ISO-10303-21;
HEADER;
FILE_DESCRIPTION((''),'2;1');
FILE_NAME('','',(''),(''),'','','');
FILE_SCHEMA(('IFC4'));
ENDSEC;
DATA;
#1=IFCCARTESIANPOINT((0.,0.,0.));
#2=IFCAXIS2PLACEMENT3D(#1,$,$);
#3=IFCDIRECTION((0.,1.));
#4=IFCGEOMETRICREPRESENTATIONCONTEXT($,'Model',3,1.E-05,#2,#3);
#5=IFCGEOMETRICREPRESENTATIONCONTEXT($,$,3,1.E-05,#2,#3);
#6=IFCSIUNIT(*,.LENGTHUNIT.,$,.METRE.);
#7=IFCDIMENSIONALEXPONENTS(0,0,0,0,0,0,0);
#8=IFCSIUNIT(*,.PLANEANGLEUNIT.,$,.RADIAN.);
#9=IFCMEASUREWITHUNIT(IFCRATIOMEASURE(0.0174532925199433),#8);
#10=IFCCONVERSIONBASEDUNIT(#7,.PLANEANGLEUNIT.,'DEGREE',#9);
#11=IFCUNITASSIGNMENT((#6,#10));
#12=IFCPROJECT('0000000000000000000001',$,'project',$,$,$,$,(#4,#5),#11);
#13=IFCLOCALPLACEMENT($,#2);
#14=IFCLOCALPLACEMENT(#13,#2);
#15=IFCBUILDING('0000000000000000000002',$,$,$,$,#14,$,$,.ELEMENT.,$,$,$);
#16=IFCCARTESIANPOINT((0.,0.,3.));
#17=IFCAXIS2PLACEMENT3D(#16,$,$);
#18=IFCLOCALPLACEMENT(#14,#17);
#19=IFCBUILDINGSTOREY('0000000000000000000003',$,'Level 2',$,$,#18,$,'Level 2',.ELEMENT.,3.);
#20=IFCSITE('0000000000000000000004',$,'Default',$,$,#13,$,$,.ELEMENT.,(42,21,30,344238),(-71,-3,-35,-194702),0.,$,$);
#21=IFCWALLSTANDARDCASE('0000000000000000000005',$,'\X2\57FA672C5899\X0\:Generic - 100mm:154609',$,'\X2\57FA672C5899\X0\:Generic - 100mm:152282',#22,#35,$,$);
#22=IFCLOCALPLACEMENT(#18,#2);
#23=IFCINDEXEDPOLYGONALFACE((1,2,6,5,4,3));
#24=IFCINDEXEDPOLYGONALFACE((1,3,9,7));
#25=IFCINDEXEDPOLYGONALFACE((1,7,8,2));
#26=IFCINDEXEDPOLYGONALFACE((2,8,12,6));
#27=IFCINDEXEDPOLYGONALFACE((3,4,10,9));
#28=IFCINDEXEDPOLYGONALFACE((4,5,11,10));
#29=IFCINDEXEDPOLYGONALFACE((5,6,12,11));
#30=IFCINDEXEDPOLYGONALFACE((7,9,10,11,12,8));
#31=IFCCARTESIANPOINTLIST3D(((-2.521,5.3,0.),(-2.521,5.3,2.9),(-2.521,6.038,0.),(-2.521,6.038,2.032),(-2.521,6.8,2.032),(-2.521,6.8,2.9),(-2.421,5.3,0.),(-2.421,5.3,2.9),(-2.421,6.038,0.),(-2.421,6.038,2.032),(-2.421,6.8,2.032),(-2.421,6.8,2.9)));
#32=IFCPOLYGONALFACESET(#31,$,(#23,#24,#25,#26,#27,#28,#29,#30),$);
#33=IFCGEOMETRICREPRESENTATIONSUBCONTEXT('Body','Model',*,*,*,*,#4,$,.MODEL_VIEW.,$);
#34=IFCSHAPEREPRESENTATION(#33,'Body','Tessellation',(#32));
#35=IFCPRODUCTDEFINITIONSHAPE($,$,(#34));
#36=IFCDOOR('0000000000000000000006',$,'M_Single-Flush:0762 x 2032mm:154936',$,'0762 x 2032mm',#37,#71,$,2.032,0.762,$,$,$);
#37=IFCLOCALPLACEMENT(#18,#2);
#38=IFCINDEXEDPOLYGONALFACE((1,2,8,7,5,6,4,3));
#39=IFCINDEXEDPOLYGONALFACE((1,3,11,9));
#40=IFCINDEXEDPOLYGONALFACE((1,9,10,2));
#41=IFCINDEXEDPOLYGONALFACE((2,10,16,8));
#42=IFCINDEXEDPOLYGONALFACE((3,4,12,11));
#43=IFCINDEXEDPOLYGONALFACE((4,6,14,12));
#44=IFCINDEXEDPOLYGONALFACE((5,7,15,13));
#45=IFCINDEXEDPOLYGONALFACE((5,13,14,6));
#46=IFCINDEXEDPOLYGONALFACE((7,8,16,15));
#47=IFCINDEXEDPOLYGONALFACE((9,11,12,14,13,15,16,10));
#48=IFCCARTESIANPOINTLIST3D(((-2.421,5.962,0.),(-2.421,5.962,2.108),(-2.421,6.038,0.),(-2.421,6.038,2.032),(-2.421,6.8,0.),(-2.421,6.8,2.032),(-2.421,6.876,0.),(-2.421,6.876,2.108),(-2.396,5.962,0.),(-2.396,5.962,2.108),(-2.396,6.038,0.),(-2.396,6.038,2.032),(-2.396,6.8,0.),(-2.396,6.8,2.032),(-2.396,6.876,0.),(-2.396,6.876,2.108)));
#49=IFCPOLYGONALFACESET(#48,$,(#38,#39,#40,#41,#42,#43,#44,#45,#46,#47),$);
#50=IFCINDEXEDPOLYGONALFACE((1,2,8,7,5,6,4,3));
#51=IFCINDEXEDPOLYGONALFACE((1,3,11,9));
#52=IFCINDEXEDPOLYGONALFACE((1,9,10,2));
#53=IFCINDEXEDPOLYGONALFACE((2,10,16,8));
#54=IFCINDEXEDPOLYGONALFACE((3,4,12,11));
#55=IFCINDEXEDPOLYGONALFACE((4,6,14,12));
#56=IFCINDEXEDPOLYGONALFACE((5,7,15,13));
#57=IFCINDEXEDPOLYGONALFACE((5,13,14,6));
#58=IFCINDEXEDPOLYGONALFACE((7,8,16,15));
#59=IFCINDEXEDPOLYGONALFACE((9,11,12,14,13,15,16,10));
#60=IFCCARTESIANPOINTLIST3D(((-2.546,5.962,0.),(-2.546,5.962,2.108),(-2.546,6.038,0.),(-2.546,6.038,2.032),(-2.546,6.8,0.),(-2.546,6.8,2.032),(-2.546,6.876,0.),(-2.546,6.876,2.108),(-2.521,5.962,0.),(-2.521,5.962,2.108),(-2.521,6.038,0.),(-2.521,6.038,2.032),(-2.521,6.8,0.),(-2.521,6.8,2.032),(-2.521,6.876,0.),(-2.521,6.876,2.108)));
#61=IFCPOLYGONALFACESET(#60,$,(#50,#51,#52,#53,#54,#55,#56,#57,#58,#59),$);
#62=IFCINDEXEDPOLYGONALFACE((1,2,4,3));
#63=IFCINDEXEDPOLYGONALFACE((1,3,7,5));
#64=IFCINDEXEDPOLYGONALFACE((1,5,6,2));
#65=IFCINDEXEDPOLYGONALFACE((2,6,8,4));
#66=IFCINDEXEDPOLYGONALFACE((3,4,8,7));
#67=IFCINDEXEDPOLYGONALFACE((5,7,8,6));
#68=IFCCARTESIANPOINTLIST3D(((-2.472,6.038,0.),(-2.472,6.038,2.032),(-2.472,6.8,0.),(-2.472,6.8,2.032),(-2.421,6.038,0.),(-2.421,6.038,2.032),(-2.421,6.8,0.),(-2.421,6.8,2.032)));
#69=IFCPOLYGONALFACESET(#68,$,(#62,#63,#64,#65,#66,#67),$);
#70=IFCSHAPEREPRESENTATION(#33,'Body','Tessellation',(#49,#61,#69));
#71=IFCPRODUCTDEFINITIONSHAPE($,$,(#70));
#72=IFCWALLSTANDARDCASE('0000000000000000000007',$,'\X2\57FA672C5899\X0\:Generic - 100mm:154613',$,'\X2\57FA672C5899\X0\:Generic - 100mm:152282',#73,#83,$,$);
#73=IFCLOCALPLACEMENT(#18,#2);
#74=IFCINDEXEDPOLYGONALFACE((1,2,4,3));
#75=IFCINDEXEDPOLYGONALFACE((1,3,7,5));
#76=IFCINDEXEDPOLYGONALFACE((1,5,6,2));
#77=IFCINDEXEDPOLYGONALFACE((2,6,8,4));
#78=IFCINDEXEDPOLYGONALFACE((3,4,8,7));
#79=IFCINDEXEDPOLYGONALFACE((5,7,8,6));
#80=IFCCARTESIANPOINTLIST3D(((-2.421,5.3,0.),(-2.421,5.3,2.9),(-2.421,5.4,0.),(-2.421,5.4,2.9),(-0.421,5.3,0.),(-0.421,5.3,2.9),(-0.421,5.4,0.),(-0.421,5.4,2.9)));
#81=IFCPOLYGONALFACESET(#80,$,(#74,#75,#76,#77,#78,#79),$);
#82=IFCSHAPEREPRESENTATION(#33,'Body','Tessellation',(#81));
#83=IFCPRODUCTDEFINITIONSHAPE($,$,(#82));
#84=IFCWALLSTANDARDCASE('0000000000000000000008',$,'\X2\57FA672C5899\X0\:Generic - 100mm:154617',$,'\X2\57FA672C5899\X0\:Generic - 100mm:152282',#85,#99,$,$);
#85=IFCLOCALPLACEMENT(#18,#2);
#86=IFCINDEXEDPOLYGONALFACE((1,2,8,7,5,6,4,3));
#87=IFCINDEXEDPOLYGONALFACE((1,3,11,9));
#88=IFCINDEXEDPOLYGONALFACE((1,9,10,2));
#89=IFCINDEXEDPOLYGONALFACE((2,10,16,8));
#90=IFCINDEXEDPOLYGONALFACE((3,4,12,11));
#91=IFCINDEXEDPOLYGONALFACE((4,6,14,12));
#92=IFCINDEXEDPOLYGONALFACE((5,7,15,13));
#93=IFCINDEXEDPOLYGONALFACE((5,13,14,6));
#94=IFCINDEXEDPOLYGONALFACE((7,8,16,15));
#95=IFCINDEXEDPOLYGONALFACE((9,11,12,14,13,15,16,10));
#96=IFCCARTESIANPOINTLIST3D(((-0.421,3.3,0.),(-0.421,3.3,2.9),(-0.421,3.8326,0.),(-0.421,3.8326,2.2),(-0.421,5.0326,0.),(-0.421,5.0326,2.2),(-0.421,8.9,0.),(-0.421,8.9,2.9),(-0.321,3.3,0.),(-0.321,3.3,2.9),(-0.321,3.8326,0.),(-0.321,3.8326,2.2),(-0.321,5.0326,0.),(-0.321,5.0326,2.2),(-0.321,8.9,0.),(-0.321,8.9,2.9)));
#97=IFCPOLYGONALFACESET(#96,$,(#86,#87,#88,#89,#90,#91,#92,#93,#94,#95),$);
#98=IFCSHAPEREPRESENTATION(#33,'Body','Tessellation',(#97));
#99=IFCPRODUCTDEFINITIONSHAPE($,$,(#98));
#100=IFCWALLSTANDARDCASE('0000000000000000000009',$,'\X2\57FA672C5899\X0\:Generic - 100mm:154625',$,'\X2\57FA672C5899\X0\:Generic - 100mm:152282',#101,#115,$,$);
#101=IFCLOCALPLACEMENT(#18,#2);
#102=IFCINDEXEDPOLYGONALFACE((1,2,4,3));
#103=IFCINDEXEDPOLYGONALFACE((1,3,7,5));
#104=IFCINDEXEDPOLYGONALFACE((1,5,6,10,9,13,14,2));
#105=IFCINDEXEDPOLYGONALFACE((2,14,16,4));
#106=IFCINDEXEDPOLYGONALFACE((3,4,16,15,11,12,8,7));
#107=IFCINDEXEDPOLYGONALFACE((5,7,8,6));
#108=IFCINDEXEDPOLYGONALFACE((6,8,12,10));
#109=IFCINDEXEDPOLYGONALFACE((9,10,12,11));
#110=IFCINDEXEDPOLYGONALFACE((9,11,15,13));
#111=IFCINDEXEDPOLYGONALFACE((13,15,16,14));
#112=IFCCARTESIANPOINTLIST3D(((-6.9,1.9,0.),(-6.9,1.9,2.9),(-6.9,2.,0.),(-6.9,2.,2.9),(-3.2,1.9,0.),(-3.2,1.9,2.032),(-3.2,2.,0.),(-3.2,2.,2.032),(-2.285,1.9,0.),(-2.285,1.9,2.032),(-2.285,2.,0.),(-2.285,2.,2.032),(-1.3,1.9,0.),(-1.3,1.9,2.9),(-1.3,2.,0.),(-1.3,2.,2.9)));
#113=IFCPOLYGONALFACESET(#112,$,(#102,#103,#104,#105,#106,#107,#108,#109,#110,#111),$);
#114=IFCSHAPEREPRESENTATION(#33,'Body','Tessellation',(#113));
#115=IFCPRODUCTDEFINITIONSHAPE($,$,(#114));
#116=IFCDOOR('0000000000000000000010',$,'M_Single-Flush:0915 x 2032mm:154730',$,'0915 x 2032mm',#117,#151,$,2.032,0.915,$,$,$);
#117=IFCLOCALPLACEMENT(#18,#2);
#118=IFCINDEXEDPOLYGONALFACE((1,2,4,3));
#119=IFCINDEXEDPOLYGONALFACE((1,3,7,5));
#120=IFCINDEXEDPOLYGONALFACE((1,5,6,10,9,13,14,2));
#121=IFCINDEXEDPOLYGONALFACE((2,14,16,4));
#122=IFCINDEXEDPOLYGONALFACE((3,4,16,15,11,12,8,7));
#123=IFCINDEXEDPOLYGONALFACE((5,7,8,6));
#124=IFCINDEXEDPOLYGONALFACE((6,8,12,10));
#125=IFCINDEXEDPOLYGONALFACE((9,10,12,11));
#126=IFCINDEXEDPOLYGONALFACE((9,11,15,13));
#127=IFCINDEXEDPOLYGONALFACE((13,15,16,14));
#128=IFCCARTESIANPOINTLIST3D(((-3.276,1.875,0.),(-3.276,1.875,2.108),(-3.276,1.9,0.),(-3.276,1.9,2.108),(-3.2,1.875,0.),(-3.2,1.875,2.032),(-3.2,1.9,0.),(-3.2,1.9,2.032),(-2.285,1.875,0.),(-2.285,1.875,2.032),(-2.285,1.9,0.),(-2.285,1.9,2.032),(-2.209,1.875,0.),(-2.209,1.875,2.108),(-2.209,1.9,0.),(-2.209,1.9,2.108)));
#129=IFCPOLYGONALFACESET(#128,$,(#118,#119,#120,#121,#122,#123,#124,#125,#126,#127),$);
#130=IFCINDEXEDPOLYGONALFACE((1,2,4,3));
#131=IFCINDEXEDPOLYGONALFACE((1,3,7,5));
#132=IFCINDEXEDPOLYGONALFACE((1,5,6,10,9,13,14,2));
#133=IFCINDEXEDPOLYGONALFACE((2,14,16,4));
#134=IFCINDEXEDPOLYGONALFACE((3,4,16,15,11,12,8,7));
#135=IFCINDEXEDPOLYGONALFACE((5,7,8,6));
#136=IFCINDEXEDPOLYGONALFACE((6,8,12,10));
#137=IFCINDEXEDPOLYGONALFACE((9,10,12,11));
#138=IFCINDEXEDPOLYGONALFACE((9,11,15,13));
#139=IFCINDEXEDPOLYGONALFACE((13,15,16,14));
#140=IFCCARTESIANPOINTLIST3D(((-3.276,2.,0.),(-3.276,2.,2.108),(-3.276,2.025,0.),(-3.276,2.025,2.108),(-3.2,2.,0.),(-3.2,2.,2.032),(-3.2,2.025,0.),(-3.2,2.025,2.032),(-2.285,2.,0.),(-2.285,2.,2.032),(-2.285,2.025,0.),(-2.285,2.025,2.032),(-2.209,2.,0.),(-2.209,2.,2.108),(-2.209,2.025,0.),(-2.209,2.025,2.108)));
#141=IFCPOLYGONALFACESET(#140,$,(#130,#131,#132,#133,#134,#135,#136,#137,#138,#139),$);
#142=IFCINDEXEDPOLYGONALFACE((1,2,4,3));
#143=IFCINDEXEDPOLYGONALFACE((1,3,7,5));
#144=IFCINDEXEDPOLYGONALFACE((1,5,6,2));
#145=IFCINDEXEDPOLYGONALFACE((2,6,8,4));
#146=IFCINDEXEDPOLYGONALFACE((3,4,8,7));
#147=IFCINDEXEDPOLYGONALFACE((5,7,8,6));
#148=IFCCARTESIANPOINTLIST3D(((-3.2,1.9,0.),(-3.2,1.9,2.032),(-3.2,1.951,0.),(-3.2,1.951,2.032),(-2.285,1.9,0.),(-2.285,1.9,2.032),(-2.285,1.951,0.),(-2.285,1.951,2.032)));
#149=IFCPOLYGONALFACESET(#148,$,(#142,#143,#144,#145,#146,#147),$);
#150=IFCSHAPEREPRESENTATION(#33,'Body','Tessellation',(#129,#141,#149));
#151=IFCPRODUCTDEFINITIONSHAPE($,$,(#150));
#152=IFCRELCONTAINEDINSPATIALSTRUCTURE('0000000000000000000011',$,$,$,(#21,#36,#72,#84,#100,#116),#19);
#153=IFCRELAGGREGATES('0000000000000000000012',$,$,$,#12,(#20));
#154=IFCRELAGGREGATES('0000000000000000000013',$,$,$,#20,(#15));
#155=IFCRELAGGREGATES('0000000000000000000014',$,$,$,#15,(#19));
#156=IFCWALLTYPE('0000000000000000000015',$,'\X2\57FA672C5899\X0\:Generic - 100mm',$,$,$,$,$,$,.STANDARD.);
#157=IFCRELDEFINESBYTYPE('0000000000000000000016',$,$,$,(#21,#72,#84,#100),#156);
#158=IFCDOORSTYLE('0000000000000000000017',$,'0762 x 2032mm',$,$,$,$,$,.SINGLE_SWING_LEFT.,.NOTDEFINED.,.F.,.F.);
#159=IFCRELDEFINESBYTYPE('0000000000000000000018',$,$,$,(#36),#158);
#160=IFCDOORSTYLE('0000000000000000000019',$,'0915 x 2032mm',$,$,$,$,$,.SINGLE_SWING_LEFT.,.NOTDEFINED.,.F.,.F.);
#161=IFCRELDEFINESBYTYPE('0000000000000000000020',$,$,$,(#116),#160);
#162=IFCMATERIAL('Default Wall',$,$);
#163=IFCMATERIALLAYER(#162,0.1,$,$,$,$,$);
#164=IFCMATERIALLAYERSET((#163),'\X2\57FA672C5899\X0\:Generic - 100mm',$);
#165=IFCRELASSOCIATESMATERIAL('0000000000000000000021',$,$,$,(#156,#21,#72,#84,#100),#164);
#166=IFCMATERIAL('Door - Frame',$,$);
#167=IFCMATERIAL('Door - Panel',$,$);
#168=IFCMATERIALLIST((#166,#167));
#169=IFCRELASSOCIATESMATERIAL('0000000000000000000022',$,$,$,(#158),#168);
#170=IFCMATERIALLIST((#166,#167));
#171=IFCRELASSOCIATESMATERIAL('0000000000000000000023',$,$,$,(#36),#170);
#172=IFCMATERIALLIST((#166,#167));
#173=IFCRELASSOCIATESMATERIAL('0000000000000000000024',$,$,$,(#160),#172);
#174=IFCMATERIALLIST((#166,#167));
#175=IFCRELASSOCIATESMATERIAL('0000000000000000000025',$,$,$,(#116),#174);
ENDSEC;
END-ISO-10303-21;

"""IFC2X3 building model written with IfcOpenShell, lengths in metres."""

from ifc_helpers import new_model, entity, si_unit, converted_unit, direction, frame, frame_2d, origin, origin_2d_with_axis, place, context, subcontext, project, spatial, polyline, rectangle, outline, extrude, clip, bounded_halfspace, source, transform, mapped, material, material_list, layer, layer_set, layer_usage, type_object, type_shapes, element, fill, save


model = new_model("IFC2X3")

# Units and contexts
model_context = context("Model", 3, precision=1e-05, world=origin(), true_north=direction((0.0, 1.0)))
context_of_model = context(None, 3, precision=1e-05, world=origin(), true_north=direction((0.0, 1.0)))
body_context = subcontext(model_context, "Body", "Model", "MODEL_VIEW")
ifc_project = project(units=[si_unit("LENGTHUNIT", "METRE"), converted_unit("PLANEANGLEUNIT", "DEGREE", entity("IfcRatioMeasure", 0.0174532925199433), si_unit("PLANEANGLEUNIT", "RADIAN"), dimensions=[0, 0, 0, 0, 0, 0, 0])], contexts=[model_context, context_of_model])

# Site, building, storey
site_placement = place(None, origin())
site = spatial("IfcSite", under=ifc_project, at=site_placement, Name="Default", CompositionType="ELEMENT", RefLatitude=(42, 21, 30, 344238), RefLongitude=(-71, -3, -35, -194702), RefElevation=0.0)
building_placement = place(site_placement, origin())
building = spatial("IfcBuilding", under=site, at=building_placement, CompositionType="ELEMENT")
storey_placement = place(building_placement, frame((0.0, 0.0, 3.0)))
storey = spatial("IfcBuildingStorey", under=building, at=storey_placement, Name="Level 2", LongName="Level 2", CompositionType="ELEMENT", Elevation=3.0)

# Shared definitions
ifc_material_1 = material(Name="Default Wall")
ifc_material_2 = material(Name="Door - Panel")
ifc_material_3 = material(Name="Door - Frame")

# Wall, opening, door
ifc_layer_1 = layer(ifc_material_1, 0.1)
ifc_layer_set_1 = layer_set([ifc_layer_1], Name="基本墙:Generic - 100mm")
ifc_layer_usage_1 = layer_usage(ifc_layer_set_1, "AXIS2", "NEGATIVE", 0.05)
wall_type_1 = type_object("IfcWallType", Name="基本墙:Generic - 100mm", PredefinedType="STANDARD", material=ifc_layer_set_1)
wall_1_placement = place(storey_placement, frame((-2.471, 5.3, 0.0), z_axis=(0.0, 0.0, 1.0), x_axis=(0.0, 1.0, 0.0)))
wall_1 = element("IfcWallStandardCase", 1, at=wall_1_placement, inside=storey, type_object=wall_type_1, material=ifc_layer_usage_1, Name="基本墙:Generic - 100mm:154609", ObjectType="基本墙:Generic - 100mm:152282", context=body_context, shape_type="Clipping", body=[
    clip(extrude(rectangle(XDim=1.5, YDim=0.1, at=frame_2d((0.75, 0.0), x_axis=(-1.0, 0.0))), origin(), (0.0, 0.0, 1.0), 3.2), bounded_halfspace(frame((0.0, -0.05, 2.9), z_axis=(0.0, 0.0, -1.0), x_axis=(-1.0, 0.0, 0.0)), True, frame((0.0, -0.05, 2.9), z_axis=(0.0, 0.0, -1.0), x_axis=(-1.0, 0.0, 0.0)), polyline([(0.0, 0.0), (0.0, 0.1), (-1.5, 0.1), (-1.5, 0.0), (-0.1, 0.0), (0.0, 0.0)]))),
])
opening_1_placement = place(wall_1_placement, frame((1.5, 0.05, 0.0)))
opening_1 = element("IfcOpeningElement", 2, at=opening_1_placement, cuts=wall_1, ObjectType="Opening", context=body_context, shape_type="SweptSolid", body=[
    extrude(rectangle(XDim=0.762, YDim=2.032, at=frame_2d((1.016, 0.381), x_axis=(0.0, -1.0))), frame((0.0, 0.0, 0.0), z_axis=(0.0, -1.0, 0.0), x_axis=(0.0, 0.0, 1.0)), (0.0, 0.0, 1.0), 0.1),
])
ifc_material_list_1 = material_list([ifc_material_3, ifc_material_2])
ifc_material_list_2 = material_list([ifc_material_3, ifc_material_2])
door_style_1 = type_object("IfcDoorStyle", Name="0762 x 2032mm", ConstructionType="NOTDEFINED", OperationType="SINGLE_SWING_LEFT", ParameterTakesPrecedence=False, Sizeable=False, material=ifc_material_list_2)
shared_shape_1 = source(origin(), body_context, "Body", "SweptSolid", [
    extrude(outline(polyline([(-0.457, -1.073), (0.457, -1.073), (0.457, 1.035), (0.381, 1.035), (0.381, -0.997), (-0.381, -0.997), (-0.381, 1.035), (-0.457, 1.035), (-0.457, -1.073)])), frame((0.381, 0.125, 1.035), z_axis=(0.0, -1.0, 0.0), x_axis=(-1.0, 0.0, 0.0)), (0.0, 0.0, 1.0), 0.025),
    extrude(outline(polyline([(-1.073, -0.457), (1.035, -0.457), (1.035, -0.381), (-0.997, -0.381), (-0.997, 0.381), (1.035, 0.381), (1.035, 0.457), (-1.073, 0.457), (-1.073, -0.457)])), frame((0.381, 0.0, 1.035), z_axis=(0.0, -1.0, 0.0), x_axis=(0.0, 0.0, -1.0)), (0.0, 0.0, 1.0), 0.025),
    extrude(rectangle(XDim=0.762, YDim=0.051, at=origin_2d_with_axis()), frame((0.381, 0.0745, 0.0)), (0.0, 0.0, 1.0), 2.032),
])
type_shapes(door_style_1, [shared_shape_1])
door_1_placement = place(opening_1_placement, frame((0.0, 0.0, 0.0), z_axis=(0.0, 0.0, 1.0), x_axis=(-1.0, 0.0, 0.0)))
door_1 = element("IfcDoor", 3, at=door_1_placement, inside=storey, type_object=door_style_1, material=ifc_material_list_1, Name="M_Single-Flush:0762 x 2032mm:154936", ObjectType="0762 x 2032mm", OverallHeight=2.032, OverallWidth=0.762, context=body_context, shape_type="MappedRepresentation", body=[
    mapped(shared_shape_1, transform((0.0, 0.0, 0.0), scale=1.0)),
])
fill(opening_1, door_1)

# Wall
ifc_layer_usage_2 = layer_usage(ifc_layer_set_1, "AXIS2", "NEGATIVE", 0.05)
wall_2_placement = place(storey_placement, frame((-0.421, 5.35, 0.0), z_axis=(0.0, 0.0, 1.0), x_axis=(-1.0, 0.0, 0.0)))
element("IfcWallStandardCase", 4, at=wall_2_placement, inside=storey, type_object=wall_type_1, material=ifc_layer_usage_2, Name="基本墙:Generic - 100mm:154613", ObjectType="基本墙:Generic - 100mm:152282", context=body_context, shape_type="Clipping", body=[
    clip(extrude(rectangle(XDim=2.0, YDim=0.1, at=frame_2d((1.0, 0.0), x_axis=(-1.0, 0.0))), origin(), (0.0, 0.0, 1.0), 3.2), bounded_halfspace(frame((0.0, -0.05, 2.9), z_axis=(0.0, 0.0, -1.0), x_axis=(0.0, 1.0, 0.0)), True, frame((0.0, -0.05, 2.9), z_axis=(0.0, 0.0, -1.0), x_axis=(0.0, 1.0, 0.0)), polyline([(0.0, 0.0), (0.1, 0.0), (0.1, 2.0), (0.0, 2.0), (0.0, 0.0)]))),
])

# Wall, opening
ifc_layer_usage_3 = layer_usage(ifc_layer_set_1, "AXIS2", "NEGATIVE", 0.05)
wall_3_placement = place(storey_placement, frame((-0.371, 8.9, 0.0), z_axis=(0.0, 0.0, 1.0), x_axis=(0.0, -1.0, 0.0)))
wall_3 = element("IfcWallStandardCase", 5, at=wall_3_placement, inside=storey, type_object=wall_type_1, material=ifc_layer_usage_3, Name="基本墙:Generic - 100mm:154617", ObjectType="基本墙:Generic - 100mm:152282", context=body_context, shape_type="Clipping", body=[
    clip(extrude(rectangle(XDim=5.6, YDim=0.1, at=frame_2d((2.8, 0.0), x_axis=(-1.0, 0.0))), origin(), (0.0, 0.0, 1.0), 3.2), bounded_halfspace(frame((0.0, -0.05, 2.9), z_axis=(0.0, 0.0, -1.0), x_axis=(1.0, 0.0, 0.0)), True, frame((0.0, -0.05, 2.9), z_axis=(0.0, 0.0, -1.0), x_axis=(1.0, 0.0, 0.0)), polyline([(0.0, 0.0), (0.0, -0.1), (5.6, -0.1), (5.6, 0.0), (3.6, 0.0), (3.5, 0.0), (2.1, 0.0), (2.0, 0.0), (0.0, 0.0)]))),
])
opening_2_placement = place(wall_3_placement, frame((5.0674, -0.05, 0.0)))
element("IfcOpeningElement", 6, at=opening_2_placement, cuts=wall_3, ObjectType="Opening", context=body_context, shape_type="SweptSolid", body=[
    extrude(rectangle(XDim=2.2, YDim=1.2, at=frame_2d((0.0, 0.0), x_axis=(1.0, 0.0))), frame((-0.6, 0.0, 1.1), z_axis=(0.0, 1.0, 0.0), x_axis=(0.0, 0.0, -1.0)), (0.0, 0.0, 1.0), 0.1),
])

# Wall, opening, door
ifc_layer_usage_4 = layer_usage(ifc_layer_set_1, "AXIS2", "NEGATIVE", 0.05)
wall_4_placement = place(storey_placement, frame((-1.3, 1.95, 0.0), z_axis=(0.0, 0.0, 1.0), x_axis=(-1.0, 0.0, 0.0)))
wall_4 = element("IfcWallStandardCase", 7, at=wall_4_placement, inside=storey, type_object=wall_type_1, material=ifc_layer_usage_4, Name="基本墙:Generic - 100mm:154625", ObjectType="基本墙:Generic - 100mm:152282", context=body_context, shape_type="Clipping", body=[
    clip(extrude(rectangle(XDim=5.6, YDim=0.1, at=frame_2d((2.8, 0.0), x_axis=(-1.0, 0.0))), origin(), (0.0, 0.0, 1.0), 3.2), bounded_halfspace(frame((0.0, -0.05, 2.9), z_axis=(0.0, 0.0, -1.0), x_axis=(0.0, 1.0, 0.0)), True, frame((0.0, -0.05, 2.9), z_axis=(0.0, 0.0, -1.0), x_axis=(0.0, 1.0, 0.0)), polyline([(0.0, 0.0), (0.1, 0.0), (0.1, 5.6), (0.0, 5.6), (0.0, 0.0)]))),
])
opening_3_placement = place(wall_4_placement, frame((0.985, -0.05, 0.0)))
opening_3 = element("IfcOpeningElement", 8, at=opening_3_placement, cuts=wall_4, ObjectType="Opening", context=body_context, shape_type="SweptSolid", body=[
    extrude(rectangle(XDim=0.915, YDim=2.032, at=frame_2d((1.016, 0.4575), x_axis=(0.0, -1.0))), frame((0.0, 0.0, 0.0), z_axis=(0.0, 1.0, 0.0), x_axis=(0.0, 0.0, 1.0)), (0.0, 0.0, 1.0), 0.1),
])
ifc_material_list_3 = material_list([ifc_material_3, ifc_material_2])
ifc_material_list_4 = material_list([ifc_material_3, ifc_material_2])
door_style_2 = type_object("IfcDoorStyle", Name="0915 x 2032mm", ConstructionType="NOTDEFINED", OperationType="SINGLE_SWING_LEFT", ParameterTakesPrecedence=False, Sizeable=False, material=ifc_material_list_4)
shared_shape_2 = source(origin(), body_context, "Body", "SweptSolid", [
    extrude(outline(polyline([(-0.5335, -1.073), (0.5335, -1.073), (0.5335, 1.035), (0.4575, 1.035), (0.4575, -0.997), (-0.4575, -0.997), (-0.4575, 1.035), (-0.5335, 1.035), (-0.5335, -1.073)])), frame((0.4575, 0.125, 1.035), z_axis=(0.0, -1.0, 0.0), x_axis=(-1.0, 0.0, 0.0)), (0.0, 0.0, 1.0), 0.025),
    extrude(outline(polyline([(-1.073, -0.5335), (1.035, -0.5335), (1.035, -0.4575), (-0.997, -0.4575), (-0.997, 0.4575), (1.035, 0.4575), (1.035, 0.5335), (-1.073, 0.5335), (-1.073, -0.5335)])), frame((0.4575, 0.0, 1.035), z_axis=(0.0, -1.0, 0.0), x_axis=(0.0, 0.0, -1.0)), (0.0, 0.0, 1.0), 0.025),
    extrude(rectangle(XDim=0.915, YDim=0.051, at=origin_2d_with_axis()), frame((0.4575, 0.0745, 0.0)), (0.0, 0.0, 1.0), 2.032),
])
type_shapes(door_style_2, [shared_shape_2])
door_2_placement = place(opening_3_placement, origin())
door_2 = element("IfcDoor", 9, at=door_2_placement, inside=storey, type_object=door_style_2, material=ifc_material_list_3, Name="M_Single-Flush:0915 x 2032mm:154730", ObjectType="0915 x 2032mm", OverallHeight=2.032, OverallWidth=0.915, context=body_context, shape_type="MappedRepresentation", body=[
    mapped(shared_shape_2, transform((0.0, 0.0, 0.0), scale=1.0)),
])
fill(opening_3, door_2)

save(model, "model.ifc")
